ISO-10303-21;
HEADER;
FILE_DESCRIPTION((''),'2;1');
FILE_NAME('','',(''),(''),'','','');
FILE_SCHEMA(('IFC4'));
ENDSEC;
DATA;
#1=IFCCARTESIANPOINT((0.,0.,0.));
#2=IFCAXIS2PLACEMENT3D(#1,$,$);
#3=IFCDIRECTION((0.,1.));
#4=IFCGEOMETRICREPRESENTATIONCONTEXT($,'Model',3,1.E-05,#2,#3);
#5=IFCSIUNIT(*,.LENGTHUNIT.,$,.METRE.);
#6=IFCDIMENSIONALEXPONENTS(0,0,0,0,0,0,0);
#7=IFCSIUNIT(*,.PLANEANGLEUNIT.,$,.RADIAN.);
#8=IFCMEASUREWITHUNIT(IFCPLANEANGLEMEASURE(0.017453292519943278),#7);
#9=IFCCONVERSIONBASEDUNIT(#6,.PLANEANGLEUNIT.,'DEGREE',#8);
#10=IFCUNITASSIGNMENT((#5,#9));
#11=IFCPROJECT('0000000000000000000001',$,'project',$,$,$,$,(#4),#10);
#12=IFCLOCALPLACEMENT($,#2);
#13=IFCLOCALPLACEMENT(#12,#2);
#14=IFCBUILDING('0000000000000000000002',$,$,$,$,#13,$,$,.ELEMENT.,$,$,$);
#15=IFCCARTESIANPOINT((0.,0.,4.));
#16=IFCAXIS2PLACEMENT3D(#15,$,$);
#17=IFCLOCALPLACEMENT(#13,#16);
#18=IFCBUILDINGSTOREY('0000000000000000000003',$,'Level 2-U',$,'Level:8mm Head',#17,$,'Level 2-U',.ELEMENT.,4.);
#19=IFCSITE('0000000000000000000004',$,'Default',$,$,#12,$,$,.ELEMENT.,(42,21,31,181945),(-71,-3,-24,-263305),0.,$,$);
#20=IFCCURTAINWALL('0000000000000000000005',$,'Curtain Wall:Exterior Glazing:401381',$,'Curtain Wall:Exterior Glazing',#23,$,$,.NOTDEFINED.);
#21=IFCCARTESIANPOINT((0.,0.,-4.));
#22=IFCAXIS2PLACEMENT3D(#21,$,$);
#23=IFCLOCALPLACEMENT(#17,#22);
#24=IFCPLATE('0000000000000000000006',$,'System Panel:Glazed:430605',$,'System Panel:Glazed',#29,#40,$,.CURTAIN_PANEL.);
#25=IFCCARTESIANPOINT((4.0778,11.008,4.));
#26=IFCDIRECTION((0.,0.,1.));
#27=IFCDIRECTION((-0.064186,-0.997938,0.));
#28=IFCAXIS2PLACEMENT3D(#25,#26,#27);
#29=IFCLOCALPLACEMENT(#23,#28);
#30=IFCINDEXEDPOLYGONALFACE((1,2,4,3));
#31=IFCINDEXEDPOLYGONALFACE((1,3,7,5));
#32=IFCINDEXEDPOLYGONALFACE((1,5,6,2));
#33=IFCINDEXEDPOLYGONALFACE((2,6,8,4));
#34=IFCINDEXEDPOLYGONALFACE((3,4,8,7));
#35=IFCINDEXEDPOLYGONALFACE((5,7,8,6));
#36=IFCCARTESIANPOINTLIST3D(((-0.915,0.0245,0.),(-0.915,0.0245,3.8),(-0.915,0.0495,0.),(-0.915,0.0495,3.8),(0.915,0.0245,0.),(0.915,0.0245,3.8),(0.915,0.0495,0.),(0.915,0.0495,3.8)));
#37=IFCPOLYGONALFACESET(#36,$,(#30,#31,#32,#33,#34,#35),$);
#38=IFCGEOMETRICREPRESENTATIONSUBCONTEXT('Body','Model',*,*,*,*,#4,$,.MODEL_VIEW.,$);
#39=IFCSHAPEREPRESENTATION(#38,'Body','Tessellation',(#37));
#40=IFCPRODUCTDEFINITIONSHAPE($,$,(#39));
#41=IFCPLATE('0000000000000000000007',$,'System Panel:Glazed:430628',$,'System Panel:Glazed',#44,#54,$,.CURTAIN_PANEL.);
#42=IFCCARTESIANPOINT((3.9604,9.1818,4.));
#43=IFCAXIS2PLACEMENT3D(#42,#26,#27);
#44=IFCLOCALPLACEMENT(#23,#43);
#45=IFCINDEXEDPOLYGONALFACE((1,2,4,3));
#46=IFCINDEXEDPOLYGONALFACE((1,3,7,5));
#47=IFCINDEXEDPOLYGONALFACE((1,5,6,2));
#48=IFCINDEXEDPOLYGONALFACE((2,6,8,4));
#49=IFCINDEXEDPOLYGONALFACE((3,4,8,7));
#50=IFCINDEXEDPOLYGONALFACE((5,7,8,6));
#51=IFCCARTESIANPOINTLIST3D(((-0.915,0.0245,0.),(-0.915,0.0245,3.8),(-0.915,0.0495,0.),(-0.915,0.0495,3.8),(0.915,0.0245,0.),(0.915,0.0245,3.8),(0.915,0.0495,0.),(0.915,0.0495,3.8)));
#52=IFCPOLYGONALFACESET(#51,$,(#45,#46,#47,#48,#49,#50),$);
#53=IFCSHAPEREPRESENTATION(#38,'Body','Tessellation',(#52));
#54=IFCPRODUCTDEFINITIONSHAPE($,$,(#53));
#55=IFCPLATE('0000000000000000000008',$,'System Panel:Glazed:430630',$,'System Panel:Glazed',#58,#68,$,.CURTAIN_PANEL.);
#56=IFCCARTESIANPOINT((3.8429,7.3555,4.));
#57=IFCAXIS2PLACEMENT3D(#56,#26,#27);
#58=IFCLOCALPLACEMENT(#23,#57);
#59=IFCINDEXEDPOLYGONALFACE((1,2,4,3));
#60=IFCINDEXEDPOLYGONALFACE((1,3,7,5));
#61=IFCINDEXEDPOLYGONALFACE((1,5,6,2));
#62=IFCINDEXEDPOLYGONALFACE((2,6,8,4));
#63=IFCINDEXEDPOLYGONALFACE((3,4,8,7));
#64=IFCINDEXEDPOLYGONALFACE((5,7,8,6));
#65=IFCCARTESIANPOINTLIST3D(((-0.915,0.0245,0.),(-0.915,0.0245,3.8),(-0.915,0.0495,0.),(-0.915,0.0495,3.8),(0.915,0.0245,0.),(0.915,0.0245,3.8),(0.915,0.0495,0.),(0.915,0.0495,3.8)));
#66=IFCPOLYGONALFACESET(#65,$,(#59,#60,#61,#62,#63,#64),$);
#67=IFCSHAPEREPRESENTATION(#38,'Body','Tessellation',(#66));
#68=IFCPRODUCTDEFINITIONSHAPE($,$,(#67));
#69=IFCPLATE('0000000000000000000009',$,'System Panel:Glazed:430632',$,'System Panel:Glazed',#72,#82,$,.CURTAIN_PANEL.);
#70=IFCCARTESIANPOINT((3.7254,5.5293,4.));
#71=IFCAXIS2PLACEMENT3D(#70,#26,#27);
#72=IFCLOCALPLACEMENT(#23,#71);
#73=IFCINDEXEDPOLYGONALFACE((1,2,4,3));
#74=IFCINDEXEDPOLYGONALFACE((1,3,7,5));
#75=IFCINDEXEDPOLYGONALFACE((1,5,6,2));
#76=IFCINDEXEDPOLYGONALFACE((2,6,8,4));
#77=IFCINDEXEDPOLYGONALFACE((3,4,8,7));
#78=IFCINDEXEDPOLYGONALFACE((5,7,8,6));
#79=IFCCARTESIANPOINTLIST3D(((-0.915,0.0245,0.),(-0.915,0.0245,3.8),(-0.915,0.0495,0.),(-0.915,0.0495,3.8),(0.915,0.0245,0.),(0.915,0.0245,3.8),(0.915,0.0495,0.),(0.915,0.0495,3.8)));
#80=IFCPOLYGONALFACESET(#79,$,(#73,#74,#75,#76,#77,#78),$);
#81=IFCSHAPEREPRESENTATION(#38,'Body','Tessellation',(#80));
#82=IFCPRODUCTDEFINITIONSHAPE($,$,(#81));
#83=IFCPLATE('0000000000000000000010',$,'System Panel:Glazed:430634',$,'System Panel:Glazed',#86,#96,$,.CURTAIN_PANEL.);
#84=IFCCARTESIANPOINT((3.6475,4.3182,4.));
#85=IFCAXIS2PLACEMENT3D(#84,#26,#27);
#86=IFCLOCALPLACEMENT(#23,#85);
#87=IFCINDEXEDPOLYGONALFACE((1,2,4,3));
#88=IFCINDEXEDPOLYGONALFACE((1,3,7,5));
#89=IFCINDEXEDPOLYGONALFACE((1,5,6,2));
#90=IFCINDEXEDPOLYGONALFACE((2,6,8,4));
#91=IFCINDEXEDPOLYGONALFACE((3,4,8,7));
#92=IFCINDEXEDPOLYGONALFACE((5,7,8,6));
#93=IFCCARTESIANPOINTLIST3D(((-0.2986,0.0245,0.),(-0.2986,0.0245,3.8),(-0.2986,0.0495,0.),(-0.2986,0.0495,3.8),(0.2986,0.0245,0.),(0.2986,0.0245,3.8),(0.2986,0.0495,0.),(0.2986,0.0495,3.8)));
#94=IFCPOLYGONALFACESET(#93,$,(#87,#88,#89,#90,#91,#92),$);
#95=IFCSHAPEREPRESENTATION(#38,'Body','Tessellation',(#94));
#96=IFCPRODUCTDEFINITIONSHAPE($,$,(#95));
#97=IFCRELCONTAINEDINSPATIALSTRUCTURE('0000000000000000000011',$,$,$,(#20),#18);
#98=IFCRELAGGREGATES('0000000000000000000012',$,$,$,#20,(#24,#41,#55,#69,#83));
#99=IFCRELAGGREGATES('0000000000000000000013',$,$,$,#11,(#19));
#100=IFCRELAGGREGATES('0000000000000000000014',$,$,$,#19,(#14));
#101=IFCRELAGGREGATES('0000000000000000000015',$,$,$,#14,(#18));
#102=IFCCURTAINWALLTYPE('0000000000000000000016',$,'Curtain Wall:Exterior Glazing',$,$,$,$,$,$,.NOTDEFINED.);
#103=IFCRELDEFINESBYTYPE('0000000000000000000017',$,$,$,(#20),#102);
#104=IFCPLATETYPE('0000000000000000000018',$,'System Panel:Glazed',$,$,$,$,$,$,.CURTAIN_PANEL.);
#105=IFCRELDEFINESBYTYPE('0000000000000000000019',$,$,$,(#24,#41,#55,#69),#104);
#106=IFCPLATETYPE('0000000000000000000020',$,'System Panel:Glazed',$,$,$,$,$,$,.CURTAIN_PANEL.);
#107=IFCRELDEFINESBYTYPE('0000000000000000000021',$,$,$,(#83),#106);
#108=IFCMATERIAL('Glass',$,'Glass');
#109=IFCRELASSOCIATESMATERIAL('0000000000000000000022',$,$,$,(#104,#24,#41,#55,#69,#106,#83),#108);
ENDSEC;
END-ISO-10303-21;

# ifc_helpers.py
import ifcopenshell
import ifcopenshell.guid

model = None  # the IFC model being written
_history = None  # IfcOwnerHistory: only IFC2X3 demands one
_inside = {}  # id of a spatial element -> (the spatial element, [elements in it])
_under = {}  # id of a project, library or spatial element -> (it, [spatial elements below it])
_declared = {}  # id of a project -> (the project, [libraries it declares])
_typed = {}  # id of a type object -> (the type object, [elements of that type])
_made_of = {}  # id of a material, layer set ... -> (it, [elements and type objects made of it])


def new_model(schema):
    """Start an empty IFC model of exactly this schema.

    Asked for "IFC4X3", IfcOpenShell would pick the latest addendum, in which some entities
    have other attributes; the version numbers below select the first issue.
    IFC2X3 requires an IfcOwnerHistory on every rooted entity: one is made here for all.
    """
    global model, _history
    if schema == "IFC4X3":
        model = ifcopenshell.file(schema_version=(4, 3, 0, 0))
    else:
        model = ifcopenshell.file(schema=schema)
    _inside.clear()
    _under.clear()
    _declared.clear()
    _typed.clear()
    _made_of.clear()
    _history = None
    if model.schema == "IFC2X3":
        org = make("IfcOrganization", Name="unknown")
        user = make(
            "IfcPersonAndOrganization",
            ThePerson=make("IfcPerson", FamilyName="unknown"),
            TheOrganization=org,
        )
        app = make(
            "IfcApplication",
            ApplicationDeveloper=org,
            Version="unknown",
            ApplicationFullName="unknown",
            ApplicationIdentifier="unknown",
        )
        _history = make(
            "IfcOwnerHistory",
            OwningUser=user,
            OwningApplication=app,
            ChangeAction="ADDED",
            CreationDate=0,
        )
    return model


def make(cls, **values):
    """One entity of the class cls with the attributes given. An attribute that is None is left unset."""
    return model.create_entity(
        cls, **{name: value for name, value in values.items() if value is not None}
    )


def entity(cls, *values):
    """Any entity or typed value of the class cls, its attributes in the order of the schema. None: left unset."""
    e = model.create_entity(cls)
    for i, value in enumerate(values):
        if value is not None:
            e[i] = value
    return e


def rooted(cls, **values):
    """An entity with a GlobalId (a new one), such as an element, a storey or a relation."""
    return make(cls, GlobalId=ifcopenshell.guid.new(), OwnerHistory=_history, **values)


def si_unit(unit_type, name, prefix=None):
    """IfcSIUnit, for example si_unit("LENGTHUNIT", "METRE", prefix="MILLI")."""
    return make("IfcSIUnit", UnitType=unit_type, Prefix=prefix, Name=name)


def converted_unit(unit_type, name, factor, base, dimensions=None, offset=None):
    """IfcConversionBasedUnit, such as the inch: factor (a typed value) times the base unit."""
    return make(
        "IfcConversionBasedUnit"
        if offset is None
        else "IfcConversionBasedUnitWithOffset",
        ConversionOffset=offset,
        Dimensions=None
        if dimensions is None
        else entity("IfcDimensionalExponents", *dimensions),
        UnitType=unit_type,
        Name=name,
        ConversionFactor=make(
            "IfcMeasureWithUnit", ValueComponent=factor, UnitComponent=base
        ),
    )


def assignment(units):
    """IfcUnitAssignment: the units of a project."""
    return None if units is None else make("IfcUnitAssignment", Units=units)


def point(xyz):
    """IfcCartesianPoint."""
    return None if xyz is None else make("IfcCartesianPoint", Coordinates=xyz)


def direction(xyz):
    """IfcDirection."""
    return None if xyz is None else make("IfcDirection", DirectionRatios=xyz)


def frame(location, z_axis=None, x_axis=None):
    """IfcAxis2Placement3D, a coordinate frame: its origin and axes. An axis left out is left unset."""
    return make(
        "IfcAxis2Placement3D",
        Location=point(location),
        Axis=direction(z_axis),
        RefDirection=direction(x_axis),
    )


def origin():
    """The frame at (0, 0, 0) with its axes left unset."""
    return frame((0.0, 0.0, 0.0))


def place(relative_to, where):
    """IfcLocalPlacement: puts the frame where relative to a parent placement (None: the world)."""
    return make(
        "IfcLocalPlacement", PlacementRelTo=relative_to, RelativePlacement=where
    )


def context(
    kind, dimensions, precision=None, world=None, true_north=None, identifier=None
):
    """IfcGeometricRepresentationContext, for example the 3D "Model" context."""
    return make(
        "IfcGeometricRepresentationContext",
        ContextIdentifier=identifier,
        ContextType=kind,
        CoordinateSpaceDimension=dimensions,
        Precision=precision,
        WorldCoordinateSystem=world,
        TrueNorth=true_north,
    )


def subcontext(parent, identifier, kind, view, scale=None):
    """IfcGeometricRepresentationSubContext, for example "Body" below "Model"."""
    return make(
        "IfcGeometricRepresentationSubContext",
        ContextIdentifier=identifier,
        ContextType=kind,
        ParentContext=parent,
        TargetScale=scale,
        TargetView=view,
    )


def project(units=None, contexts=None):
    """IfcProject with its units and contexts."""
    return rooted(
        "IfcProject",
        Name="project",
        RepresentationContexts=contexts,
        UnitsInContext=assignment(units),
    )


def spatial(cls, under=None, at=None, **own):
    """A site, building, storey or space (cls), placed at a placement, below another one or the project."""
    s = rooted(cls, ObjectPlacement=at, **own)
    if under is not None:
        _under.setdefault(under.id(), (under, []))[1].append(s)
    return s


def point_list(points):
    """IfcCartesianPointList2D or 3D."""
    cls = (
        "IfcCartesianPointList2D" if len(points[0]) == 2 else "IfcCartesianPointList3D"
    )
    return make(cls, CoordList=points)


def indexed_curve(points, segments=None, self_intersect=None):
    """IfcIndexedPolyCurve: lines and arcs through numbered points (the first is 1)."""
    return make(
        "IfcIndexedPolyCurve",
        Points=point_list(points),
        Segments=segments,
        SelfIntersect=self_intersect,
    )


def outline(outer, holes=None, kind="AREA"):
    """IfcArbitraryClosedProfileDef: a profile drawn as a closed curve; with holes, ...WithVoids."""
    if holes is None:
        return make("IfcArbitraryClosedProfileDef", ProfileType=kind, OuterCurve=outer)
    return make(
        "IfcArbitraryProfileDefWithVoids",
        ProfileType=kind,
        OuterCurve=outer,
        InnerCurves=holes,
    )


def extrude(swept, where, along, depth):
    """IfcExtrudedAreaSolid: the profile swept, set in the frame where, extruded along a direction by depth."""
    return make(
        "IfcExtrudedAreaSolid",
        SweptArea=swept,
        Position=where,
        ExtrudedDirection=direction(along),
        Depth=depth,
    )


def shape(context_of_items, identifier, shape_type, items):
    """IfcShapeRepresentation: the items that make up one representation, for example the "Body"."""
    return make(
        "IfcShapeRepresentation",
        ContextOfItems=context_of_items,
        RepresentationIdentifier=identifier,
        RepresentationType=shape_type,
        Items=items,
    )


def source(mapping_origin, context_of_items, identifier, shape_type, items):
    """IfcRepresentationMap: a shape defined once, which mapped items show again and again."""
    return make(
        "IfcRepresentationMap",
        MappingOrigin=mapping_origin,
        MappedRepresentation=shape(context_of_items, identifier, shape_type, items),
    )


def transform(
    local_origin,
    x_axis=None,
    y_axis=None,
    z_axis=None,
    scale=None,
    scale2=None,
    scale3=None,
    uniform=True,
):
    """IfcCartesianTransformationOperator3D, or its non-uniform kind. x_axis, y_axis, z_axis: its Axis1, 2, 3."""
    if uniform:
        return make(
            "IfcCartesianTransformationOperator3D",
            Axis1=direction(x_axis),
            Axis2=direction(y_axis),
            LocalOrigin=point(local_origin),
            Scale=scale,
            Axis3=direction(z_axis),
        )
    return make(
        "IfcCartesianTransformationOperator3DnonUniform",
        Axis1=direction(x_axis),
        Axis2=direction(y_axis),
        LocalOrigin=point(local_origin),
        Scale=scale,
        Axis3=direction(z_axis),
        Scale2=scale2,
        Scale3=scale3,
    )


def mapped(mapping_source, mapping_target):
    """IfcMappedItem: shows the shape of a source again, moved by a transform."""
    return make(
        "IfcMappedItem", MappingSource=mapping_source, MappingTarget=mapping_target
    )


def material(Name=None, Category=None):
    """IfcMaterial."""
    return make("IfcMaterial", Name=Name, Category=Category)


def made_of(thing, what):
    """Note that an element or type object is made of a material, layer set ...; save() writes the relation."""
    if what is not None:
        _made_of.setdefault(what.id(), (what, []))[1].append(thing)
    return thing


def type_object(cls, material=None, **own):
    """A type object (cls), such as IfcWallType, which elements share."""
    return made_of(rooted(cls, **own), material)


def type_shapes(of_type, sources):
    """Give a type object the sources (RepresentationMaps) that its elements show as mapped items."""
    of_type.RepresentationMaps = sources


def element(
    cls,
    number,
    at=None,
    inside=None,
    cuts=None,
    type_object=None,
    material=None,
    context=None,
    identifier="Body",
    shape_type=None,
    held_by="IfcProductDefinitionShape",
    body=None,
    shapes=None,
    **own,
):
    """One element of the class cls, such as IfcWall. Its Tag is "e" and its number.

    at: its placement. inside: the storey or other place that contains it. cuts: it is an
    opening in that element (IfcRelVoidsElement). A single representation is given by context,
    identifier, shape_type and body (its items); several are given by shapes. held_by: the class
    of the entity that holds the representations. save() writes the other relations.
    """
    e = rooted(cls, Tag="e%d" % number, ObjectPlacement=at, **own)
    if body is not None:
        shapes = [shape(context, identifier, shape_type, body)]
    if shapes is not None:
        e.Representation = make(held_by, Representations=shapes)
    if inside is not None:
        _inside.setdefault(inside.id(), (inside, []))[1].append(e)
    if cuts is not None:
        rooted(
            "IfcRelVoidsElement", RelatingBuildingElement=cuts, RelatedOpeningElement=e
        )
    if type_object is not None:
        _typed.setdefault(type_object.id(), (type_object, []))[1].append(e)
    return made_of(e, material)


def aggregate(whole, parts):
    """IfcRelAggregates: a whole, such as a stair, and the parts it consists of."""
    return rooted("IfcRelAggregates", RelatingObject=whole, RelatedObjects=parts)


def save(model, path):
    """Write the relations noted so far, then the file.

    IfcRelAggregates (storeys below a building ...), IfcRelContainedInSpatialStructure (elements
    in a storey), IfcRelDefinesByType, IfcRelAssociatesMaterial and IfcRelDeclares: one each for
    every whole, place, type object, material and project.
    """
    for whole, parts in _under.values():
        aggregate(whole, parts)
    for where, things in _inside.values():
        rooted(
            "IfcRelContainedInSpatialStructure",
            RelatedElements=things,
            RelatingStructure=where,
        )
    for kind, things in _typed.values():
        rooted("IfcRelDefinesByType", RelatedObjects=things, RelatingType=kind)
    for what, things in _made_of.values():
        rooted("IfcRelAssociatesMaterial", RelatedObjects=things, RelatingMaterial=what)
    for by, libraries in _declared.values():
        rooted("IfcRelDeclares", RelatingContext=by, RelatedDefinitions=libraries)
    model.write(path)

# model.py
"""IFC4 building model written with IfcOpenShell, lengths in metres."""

from ifc_helpers import new_model, entity, si_unit, converted_unit, direction, frame, origin, place, context, subcontext, project, spatial, indexed_curve, outline, extrude, source, transform, mapped, material, type_object, type_shapes, element, aggregate, save


model = new_model("IFC4")

# Units and contexts
model_context = context("Model", 3, precision=1e-05, world=origin(), true_north=direction((0.0, 1.0)))
body_context = subcontext(model_context, "Body", "Model", "MODEL_VIEW")
ifc_project = project(units=[si_unit("LENGTHUNIT", "METRE"), converted_unit("PLANEANGLEUNIT", "DEGREE", entity("IfcPlaneAngleMeasure", 0.017453292519943278), si_unit("PLANEANGLEUNIT", "RADIAN"), dimensions=[0, 0, 0, 0, 0, 0, 0])], contexts=[model_context])

# Site, building, storey
site_placement = place(None, origin())
site = spatial("IfcSite", under=ifc_project, at=site_placement, Name="Default", CompositionType="ELEMENT", RefLatitude=(42, 21, 31, 181945), RefLongitude=(-71, -3, -24, -263305), RefElevation=0.0)
building_placement = place(site_placement, origin())
building = spatial("IfcBuilding", under=site, at=building_placement, CompositionType="ELEMENT")
storey_placement = place(building_placement, frame((0.0, 0.0, 4.0)))
storey = spatial("IfcBuildingStorey", under=building, at=storey_placement, Name="Level 2-U", ObjectType="Level:8mm Head", LongName="Level 2-U", CompositionType="ELEMENT", Elevation=4.0)

# Curtain wall, plates
curtain_wall_type = type_object("IfcCurtainWallType", Name="Curtain Wall:Exterior Glazing", PredefinedType="NOTDEFINED")
curtain_wall_placement = place(storey_placement, frame((0.0, 0.0, -4.0)))
curtain_wall = element("IfcCurtainWall", 1, at=curtain_wall_placement, inside=storey, type_object=curtain_wall_type, Name="Curtain Wall:Exterior Glazing:401381", ObjectType="Curtain Wall:Exterior Glazing", PredefinedType="NOTDEFINED")
ifc_material_1 = material(Name="Glass", Category="Glass")
plate_type_1 = type_object("IfcPlateType", Name="System Panel:Glazed", PredefinedType="CURTAIN_PANEL", material=ifc_material_1)
shared_shape_1 = source(origin(), body_context, "Body", "SweptSolid", [
    extrude(outline(indexed_curve([(-0.0125, -0.915), (0.0125, -0.915), (0.0125, 0.915), (-0.0125, 0.915), (-0.0125, -0.915)], self_intersect=False)), frame((0.0, 0.037, 0.0), z_axis=(0.0, 0.0, 1.0), x_axis=(0.0, 1.0, 0.0)), (0.0, 0.0, 1.0), 3.8),
])
type_shapes(plate_type_1, [shared_shape_1])
plate_1_placement = place(curtain_wall_placement, frame((4.0778, 11.008, 4.0), z_axis=(0.0, 0.0, 1.0), x_axis=(-0.064186, -0.997938, 0.0)))
plate_1 = element("IfcPlate", 2, at=plate_1_placement, type_object=plate_type_1, material=ifc_material_1, Name="System Panel:Glazed:430605", ObjectType="System Panel:Glazed", PredefinedType="CURTAIN_PANEL", context=body_context, shape_type="MappedRepresentation", body=[
    mapped(shared_shape_1, transform((0.0, 0.0, 0.0), scale=1.0)),
])
plate_2_placement = place(curtain_wall_placement, frame((3.9604, 9.1818, 4.0), z_axis=(0.0, 0.0, 1.0), x_axis=(-0.064186, -0.997938, 0.0)))
plate_2 = element("IfcPlate", 3, at=plate_2_placement, type_object=plate_type_1, material=ifc_material_1, Name="System Panel:Glazed:430628", ObjectType="System Panel:Glazed", PredefinedType="CURTAIN_PANEL", context=body_context, shape_type="MappedRepresentation", body=[
    mapped(shared_shape_1, transform((0.0, 0.0, 0.0), scale=1.0)),
])
plate_3_placement = place(curtain_wall_placement, frame((3.8429, 7.3555, 4.0), z_axis=(0.0, 0.0, 1.0), x_axis=(-0.064186, -0.997938, 0.0)))
plate_3 = element("IfcPlate", 4, at=plate_3_placement, type_object=plate_type_1, material=ifc_material_1, Name="System Panel:Glazed:430630", ObjectType="System Panel:Glazed", PredefinedType="CURTAIN_PANEL", context=body_context, shape_type="MappedRepresentation", body=[
    mapped(shared_shape_1, transform((0.0, 0.0, 0.0), scale=1.0)),
])
plate_4_placement = place(curtain_wall_placement, frame((3.7254, 5.5293, 4.0), z_axis=(0.0, 0.0, 1.0), x_axis=(-0.064186, -0.997938, 0.0)))
plate_4 = element("IfcPlate", 5, at=plate_4_placement, type_object=plate_type_1, material=ifc_material_1, Name="System Panel:Glazed:430632", ObjectType="System Panel:Glazed", PredefinedType="CURTAIN_PANEL", context=body_context, shape_type="MappedRepresentation", body=[
    mapped(shared_shape_1, transform((0.0, 0.0, 0.0), scale=1.0)),
])
plate_type_2 = type_object("IfcPlateType", Name="System Panel:Glazed", PredefinedType="CURTAIN_PANEL", material=ifc_material_1)
shared_shape_2 = source(origin(), body_context, "Body", "SweptSolid", [
    extrude(outline(indexed_curve([(-0.0125, -0.2986), (0.0125, -0.2986), (0.0125, 0.2986), (-0.0125, 0.2986), (-0.0125, -0.2986)], self_intersect=False)), frame((0.0, 0.037, 0.0), z_axis=(0.0, 0.0, 1.0), x_axis=(0.0, 1.0, 0.0)), (0.0, 0.0, 1.0), 3.8),
])
type_shapes(plate_type_2, [shared_shape_2])
plate_5_placement = place(curtain_wall_placement, frame((3.6475, 4.3182, 4.0), z_axis=(0.0, 0.0, 1.0), x_axis=(-0.064186, -0.997938, 0.0)))
plate_5 = element("IfcPlate", 6, at=plate_5_placement, type_object=plate_type_2, material=ifc_material_1, Name="System Panel:Glazed:430634", ObjectType="System Panel:Glazed", PredefinedType="CURTAIN_PANEL", context=body_context, shape_type="MappedRepresentation", body=[
    mapped(shared_shape_2, transform((0.0, 0.0, 0.0), scale=1.0)),
])
aggregate(curtain_wall, [plate_1, plate_2, plate_3, plate_4, plate_5])

save(model, "model.ifc")
